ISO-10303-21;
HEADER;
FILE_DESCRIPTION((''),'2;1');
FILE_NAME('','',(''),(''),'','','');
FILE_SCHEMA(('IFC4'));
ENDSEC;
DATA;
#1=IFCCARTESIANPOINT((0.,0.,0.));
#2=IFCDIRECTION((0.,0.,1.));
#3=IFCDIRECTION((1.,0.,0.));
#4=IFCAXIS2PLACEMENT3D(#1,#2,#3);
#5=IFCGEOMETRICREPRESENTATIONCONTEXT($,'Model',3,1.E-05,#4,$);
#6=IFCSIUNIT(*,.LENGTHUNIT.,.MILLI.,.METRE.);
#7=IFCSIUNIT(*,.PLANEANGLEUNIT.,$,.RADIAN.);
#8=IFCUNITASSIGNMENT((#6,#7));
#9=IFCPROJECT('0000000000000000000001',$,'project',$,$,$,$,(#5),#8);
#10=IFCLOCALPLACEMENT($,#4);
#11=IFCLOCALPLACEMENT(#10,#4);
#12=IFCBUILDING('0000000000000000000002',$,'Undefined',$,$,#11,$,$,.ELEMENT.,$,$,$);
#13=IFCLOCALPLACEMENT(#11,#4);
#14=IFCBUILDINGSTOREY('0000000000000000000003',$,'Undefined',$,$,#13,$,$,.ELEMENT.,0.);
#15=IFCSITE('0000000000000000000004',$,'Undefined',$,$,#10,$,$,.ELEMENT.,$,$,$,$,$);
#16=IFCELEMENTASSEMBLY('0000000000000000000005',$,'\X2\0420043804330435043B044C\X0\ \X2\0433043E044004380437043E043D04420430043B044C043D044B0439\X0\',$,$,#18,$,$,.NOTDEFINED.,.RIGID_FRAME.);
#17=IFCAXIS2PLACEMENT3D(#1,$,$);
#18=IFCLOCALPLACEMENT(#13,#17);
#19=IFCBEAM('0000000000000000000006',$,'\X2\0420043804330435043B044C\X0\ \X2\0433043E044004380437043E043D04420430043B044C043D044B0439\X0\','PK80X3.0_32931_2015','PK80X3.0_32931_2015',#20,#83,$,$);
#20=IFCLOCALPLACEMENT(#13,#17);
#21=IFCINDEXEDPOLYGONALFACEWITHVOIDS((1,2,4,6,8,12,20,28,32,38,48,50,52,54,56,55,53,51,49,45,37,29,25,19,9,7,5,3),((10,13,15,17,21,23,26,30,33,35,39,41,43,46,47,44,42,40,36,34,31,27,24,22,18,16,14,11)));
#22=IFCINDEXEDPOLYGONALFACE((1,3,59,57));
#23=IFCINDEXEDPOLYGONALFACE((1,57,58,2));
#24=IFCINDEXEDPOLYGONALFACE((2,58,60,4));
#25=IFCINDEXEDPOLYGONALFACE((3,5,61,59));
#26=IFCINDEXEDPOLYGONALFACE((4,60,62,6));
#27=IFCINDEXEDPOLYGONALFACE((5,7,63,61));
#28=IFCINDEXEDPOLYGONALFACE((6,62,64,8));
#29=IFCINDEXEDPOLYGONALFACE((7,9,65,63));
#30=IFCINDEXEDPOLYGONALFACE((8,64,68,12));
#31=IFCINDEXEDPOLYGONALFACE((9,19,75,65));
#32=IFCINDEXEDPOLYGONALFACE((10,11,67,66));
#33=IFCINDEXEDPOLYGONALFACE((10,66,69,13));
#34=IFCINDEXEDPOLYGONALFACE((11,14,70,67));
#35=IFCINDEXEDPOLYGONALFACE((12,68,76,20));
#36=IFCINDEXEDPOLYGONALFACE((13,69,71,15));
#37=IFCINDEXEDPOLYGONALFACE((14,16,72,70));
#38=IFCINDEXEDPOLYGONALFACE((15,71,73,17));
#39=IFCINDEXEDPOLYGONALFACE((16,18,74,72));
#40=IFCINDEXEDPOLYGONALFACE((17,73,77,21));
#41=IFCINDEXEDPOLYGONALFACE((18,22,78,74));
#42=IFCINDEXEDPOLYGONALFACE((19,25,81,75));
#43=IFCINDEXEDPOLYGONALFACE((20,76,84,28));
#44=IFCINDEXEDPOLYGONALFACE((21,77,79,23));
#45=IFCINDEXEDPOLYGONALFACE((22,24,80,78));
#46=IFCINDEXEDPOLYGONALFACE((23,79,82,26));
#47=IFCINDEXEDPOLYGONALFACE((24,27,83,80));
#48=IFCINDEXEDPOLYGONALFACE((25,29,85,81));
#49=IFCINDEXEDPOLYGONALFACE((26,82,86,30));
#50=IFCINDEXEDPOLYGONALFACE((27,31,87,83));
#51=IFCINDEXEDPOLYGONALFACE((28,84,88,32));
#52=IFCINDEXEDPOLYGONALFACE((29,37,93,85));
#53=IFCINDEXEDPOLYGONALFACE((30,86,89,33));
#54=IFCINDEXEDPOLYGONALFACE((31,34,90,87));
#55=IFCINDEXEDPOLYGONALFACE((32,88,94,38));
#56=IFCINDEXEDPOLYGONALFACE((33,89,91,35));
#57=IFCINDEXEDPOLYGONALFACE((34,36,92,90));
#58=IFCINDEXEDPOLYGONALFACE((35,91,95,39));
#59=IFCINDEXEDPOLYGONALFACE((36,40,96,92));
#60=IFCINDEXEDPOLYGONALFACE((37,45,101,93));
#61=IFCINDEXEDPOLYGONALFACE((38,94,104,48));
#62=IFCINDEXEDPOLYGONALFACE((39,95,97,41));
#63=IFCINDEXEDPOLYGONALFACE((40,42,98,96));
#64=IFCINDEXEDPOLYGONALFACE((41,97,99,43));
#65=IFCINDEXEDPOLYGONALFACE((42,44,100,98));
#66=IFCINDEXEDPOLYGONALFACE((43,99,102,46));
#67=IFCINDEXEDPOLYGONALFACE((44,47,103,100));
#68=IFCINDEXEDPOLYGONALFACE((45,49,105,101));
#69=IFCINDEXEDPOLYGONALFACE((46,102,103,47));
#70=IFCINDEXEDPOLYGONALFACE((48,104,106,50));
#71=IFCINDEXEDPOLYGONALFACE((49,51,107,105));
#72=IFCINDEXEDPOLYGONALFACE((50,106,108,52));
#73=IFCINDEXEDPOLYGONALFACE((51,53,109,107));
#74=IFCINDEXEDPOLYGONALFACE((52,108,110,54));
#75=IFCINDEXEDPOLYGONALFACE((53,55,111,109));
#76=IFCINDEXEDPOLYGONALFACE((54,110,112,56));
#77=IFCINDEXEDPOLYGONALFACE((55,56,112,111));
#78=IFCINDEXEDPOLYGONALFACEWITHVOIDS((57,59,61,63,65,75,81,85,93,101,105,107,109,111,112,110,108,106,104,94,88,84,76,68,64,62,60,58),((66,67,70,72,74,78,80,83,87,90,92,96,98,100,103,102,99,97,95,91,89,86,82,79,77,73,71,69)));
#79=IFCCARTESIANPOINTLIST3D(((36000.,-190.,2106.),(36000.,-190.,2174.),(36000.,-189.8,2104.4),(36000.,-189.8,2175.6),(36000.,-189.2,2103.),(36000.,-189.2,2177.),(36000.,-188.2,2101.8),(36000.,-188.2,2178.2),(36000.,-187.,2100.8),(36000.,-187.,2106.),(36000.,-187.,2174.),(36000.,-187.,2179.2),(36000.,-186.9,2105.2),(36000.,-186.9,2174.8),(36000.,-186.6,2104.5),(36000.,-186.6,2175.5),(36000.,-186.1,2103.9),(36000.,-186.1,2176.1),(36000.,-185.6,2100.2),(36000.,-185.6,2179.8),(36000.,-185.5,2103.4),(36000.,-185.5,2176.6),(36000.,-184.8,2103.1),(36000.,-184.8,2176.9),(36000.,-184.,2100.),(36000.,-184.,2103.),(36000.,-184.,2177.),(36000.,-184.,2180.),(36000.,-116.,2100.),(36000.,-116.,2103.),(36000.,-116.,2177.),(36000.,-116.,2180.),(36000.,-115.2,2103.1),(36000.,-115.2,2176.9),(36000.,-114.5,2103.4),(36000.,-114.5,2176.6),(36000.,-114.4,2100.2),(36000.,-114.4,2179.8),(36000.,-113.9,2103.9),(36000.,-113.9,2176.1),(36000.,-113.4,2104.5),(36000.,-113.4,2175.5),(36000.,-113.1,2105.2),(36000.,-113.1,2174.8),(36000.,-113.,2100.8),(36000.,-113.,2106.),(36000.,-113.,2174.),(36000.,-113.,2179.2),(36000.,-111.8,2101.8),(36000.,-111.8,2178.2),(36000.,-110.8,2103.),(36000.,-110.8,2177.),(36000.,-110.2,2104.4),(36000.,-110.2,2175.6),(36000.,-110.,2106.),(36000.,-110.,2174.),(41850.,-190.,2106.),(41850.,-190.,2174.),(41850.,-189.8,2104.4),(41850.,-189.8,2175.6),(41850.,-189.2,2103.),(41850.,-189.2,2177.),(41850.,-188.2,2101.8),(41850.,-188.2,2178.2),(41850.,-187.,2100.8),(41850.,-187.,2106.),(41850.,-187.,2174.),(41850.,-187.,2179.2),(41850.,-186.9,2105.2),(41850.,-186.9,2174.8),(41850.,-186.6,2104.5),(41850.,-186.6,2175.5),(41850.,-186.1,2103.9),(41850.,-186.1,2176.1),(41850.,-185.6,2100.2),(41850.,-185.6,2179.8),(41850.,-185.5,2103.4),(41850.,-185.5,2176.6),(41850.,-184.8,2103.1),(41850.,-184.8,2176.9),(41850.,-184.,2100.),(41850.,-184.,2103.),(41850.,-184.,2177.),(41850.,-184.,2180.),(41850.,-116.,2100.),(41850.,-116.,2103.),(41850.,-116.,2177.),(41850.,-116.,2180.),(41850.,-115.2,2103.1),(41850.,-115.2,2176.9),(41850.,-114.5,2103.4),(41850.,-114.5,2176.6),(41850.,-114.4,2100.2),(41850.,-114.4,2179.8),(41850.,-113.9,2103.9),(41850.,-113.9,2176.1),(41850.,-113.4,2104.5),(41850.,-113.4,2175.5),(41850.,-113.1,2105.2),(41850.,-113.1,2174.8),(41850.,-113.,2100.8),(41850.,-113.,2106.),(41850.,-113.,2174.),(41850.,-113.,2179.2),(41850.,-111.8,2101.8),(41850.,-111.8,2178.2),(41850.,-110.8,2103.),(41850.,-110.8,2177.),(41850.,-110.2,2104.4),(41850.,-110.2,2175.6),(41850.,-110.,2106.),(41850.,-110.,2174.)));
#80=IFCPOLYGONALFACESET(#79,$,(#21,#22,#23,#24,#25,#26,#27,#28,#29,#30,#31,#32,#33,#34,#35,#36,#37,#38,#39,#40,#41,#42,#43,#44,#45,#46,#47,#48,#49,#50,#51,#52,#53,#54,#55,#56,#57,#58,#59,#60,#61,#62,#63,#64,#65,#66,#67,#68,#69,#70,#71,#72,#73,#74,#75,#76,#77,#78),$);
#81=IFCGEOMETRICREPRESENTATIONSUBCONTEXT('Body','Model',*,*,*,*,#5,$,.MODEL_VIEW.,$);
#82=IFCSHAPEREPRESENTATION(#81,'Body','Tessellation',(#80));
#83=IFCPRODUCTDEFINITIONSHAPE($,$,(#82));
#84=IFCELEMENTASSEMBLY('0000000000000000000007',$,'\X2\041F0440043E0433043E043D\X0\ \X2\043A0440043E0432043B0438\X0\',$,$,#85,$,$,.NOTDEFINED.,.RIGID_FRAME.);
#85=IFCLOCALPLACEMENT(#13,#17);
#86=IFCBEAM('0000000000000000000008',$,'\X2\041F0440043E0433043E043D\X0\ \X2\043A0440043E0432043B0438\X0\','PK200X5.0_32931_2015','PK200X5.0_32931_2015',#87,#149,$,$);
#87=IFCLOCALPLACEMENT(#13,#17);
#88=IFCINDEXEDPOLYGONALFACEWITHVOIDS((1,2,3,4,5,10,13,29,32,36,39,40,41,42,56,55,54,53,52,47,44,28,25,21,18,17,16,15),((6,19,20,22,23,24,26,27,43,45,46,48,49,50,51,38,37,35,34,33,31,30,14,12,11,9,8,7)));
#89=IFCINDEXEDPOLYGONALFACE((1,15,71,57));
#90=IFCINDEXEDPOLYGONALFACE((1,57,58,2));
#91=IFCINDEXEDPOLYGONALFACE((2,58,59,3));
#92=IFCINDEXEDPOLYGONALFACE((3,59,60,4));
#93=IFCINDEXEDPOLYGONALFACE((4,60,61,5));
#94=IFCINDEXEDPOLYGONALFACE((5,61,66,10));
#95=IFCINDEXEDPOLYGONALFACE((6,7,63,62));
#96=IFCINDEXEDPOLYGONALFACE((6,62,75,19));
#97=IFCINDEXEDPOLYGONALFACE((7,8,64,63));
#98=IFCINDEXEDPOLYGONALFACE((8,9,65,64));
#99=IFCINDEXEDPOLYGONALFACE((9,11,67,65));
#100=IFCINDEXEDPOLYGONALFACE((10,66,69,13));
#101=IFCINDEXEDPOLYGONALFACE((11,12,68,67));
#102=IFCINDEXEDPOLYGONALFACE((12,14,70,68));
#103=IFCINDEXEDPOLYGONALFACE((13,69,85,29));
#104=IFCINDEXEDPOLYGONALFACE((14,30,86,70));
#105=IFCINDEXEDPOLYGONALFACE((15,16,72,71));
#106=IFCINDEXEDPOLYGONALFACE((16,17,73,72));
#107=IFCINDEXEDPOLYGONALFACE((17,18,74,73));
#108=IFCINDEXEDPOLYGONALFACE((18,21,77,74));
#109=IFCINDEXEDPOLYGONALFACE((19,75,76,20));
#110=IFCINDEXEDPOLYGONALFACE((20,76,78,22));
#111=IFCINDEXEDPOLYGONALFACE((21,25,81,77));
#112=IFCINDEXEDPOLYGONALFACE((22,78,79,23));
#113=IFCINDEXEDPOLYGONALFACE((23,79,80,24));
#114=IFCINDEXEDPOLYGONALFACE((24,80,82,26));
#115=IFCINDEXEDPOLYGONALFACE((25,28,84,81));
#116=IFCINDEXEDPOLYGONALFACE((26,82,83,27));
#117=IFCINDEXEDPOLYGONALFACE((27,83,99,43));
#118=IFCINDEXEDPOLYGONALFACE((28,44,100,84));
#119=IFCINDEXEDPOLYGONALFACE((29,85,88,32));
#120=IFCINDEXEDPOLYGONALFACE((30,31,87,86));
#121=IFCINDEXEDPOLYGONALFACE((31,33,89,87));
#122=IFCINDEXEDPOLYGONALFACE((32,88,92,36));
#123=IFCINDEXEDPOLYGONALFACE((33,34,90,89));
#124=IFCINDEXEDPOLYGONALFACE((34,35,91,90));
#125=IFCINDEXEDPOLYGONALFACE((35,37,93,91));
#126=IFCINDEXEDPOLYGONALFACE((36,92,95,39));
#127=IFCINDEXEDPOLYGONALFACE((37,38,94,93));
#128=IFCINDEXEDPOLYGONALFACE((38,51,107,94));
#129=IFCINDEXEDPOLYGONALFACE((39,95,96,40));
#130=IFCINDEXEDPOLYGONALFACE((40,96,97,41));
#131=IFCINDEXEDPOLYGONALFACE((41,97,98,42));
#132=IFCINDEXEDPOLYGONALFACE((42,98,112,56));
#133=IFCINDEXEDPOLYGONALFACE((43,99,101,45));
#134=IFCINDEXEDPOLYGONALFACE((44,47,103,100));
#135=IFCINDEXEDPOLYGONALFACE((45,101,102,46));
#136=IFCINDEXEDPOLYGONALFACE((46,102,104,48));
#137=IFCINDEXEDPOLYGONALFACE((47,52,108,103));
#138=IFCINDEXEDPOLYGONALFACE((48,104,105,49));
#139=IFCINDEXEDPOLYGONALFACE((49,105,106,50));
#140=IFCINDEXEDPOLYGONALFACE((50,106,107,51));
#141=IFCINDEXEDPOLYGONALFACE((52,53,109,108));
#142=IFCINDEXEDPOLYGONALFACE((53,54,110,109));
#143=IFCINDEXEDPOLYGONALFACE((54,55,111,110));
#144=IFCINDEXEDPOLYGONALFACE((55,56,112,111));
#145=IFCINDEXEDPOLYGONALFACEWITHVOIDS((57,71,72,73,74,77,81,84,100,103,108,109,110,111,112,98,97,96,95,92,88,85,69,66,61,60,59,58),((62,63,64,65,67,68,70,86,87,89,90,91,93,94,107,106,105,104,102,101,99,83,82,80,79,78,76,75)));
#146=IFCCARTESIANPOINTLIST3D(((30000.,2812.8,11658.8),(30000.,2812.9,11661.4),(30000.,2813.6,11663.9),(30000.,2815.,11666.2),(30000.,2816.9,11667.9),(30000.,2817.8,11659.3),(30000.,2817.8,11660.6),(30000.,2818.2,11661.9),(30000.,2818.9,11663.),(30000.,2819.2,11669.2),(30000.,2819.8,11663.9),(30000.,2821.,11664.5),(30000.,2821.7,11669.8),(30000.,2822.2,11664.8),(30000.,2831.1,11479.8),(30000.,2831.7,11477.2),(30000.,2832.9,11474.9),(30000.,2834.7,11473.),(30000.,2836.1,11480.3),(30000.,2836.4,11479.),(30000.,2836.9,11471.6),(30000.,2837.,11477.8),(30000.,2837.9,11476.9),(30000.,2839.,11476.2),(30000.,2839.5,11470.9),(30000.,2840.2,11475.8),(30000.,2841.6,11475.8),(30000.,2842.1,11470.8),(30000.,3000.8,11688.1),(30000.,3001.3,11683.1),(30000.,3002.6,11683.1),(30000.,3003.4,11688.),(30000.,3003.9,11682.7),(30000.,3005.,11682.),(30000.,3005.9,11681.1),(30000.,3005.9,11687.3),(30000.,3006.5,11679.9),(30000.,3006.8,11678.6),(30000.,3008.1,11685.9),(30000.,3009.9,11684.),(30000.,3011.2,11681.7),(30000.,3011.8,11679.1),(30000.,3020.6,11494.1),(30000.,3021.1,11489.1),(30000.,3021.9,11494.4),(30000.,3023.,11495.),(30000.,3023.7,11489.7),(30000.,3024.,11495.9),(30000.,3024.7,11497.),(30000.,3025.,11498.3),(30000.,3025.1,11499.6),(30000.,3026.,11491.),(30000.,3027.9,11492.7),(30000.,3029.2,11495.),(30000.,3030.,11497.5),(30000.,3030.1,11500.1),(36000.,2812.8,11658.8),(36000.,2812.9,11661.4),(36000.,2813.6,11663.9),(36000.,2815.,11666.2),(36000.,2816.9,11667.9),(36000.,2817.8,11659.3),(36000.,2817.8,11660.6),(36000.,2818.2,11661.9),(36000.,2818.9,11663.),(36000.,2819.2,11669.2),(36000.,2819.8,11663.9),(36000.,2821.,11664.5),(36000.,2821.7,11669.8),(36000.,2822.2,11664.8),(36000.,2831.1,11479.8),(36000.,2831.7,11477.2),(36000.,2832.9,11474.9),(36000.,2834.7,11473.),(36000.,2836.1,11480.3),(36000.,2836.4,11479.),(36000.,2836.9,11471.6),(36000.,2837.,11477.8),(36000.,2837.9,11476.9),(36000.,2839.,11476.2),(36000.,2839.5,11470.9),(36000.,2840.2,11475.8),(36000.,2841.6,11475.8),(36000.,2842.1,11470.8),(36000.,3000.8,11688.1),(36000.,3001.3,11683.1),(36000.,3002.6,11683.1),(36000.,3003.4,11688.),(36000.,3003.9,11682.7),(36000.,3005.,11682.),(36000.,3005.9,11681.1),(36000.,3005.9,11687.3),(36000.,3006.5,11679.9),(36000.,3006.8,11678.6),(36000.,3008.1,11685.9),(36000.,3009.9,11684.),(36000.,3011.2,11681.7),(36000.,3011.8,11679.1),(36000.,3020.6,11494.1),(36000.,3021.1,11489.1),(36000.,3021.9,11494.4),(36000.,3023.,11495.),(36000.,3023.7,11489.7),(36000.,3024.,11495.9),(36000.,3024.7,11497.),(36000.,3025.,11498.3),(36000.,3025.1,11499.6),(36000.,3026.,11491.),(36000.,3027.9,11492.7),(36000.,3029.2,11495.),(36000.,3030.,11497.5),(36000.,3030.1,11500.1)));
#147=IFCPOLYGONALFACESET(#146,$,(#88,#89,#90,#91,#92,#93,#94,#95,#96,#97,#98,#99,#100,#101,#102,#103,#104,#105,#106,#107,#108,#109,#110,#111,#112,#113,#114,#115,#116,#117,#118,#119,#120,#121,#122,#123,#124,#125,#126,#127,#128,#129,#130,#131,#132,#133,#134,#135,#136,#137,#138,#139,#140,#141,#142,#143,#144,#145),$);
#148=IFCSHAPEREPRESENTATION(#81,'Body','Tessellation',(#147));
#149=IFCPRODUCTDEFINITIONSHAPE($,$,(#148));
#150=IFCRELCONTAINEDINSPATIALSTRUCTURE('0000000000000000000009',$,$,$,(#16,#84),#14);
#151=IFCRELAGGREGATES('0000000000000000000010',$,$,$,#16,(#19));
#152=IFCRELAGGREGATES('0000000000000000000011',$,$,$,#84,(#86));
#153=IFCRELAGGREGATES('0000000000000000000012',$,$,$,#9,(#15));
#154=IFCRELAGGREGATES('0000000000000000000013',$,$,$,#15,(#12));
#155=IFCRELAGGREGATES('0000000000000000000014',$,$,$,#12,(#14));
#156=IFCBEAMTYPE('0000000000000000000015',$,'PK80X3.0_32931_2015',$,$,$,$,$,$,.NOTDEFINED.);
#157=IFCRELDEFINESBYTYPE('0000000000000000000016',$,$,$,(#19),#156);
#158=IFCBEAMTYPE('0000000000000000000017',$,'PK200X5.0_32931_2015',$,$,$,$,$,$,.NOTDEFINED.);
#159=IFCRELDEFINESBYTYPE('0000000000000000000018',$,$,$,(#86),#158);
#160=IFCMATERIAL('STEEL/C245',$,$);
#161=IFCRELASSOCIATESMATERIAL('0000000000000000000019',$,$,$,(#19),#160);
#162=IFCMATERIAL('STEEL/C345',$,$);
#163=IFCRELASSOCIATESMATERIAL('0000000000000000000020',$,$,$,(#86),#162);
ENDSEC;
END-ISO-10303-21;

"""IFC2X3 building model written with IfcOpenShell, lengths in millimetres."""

from ifc_helpers import new_model, si_unit, frame, origin_with_axes, origin_2d_with_axis, place, context, subcontext, project, spatial, hollow_rectangle, extrude, material, type_object, element, aggregate, save


model = new_model("IFC2X3")

# Units and contexts
model_context = context("Model", 3, precision=1e-05, world=origin_with_axes())
body_context = subcontext(model_context, "Body", "Model", "MODEL_VIEW")
ifc_project = project(units=[si_unit("LENGTHUNIT", "METRE", prefix="MILLI"), si_unit("PLANEANGLEUNIT", "RADIAN")], contexts=[model_context])

# Site, building, storey
site_placement = place(None, origin_with_axes())
site = spatial("IfcSite", under=ifc_project, at=site_placement, Name="Undefined", CompositionType="ELEMENT")
building_placement = place(site_placement, origin_with_axes())
building = spatial("IfcBuilding", under=site, at=building_placement, Name="Undefined", CompositionType="ELEMENT")
storey_placement = place(building_placement, origin_with_axes())
storey = spatial("IfcBuildingStorey", under=building, at=storey_placement, Name="Undefined", CompositionType="ELEMENT", Elevation=0.0)

# Shared definitions
ifc_material_1 = material(Name="STEEL/C245")

# Element assemblies, beams
beam_type_1 = type_object("IfcBeamType", Name="PK80X3.0_32931_2015", PredefinedType="NOTDEFINED")
assembly_1_placement = place(storey_placement, origin_with_axes())
assembly_1 = element("IfcElementAssembly", 1, at=assembly_1_placement, inside=storey, Name="Ригель горизонтальный", AssemblyPlace="NOTDEFINED", PredefinedType="RIGID_FRAME")
beam_1_placement = place(assembly_1_placement, frame((36000.0, -150.0, 2140.0), z_axis=(0.0, 0.0, 1.0), x_axis=(1.0, 0.0, 0.0)))
beam_1 = element("IfcBeam", 2, at=beam_1_placement, type_object=beam_type_1, material=ifc_material_1, Name="Ригель горизонтальный", Description="PK80X3.0_32931_2015", ObjectType="PK80X3.0_32931_2015", context=body_context, shape_type="SweptSolid", body=[
    extrude(hollow_rectangle(XDim=80.0, YDim=80.0, WallThickness=3.0, InnerFilletRadius=3.0, OuterFilletRadius=6.0, at=origin_2d_with_axis()), frame((5850.0, 0.0, 0.0), z_axis=(-1.0, 0.0, 0.0), x_axis=(0.0, -1.0, 0.0)), (0.0, 0.0, 1.0), 5850.0),
])
aggregate(assembly_1, [beam_1])
assembly_2_placement = place(storey_placement, origin_with_axes())
assembly_2 = element("IfcElementAssembly", 3, at=assembly_2_placement, inside=storey, Name="Прогон кровли", AssemblyPlace="NOTDEFINED", PredefinedType="RIGID_FRAME")
ifc_material_2 = material(Name="STEEL/C345")
beam_type_2 = type_object("IfcBeamType", Name="PK200X5.0_32931_2015", PredefinedType="NOTDEFINED")
beam_2_placement = place(assembly_2_placement, frame((36000.0, 2921.4, 11579.4), z_axis=(0.0, -0.101645, 0.994821), x_axis=(-1.0, 0.0, 0.0)))
beam_2 = element("IfcBeam", 4, at=beam_2_placement, type_object=beam_type_2, material=ifc_material_2, Name="Прогон кровли", Description="PK200X5.0_32931_2015", ObjectType="PK200X5.0_32931_2015", context=body_context, shape_type="SweptSolid", body=[
    extrude(hollow_rectangle(XDim=200.0, YDim=200.0, WallThickness=5.0, InnerFilletRadius=5.0, OuterFilletRadius=10.0, at=origin_2d_with_axis()), frame((6000.0, 0.0, 0.0), z_axis=(-1.0, 0.0, 0.0), x_axis=(0.0, -1.0, 0.0)), (0.0, 0.0, 1.0), 6000.0),
])
aggregate(assembly_2, [beam_2])

save(model, "model.ifc")
